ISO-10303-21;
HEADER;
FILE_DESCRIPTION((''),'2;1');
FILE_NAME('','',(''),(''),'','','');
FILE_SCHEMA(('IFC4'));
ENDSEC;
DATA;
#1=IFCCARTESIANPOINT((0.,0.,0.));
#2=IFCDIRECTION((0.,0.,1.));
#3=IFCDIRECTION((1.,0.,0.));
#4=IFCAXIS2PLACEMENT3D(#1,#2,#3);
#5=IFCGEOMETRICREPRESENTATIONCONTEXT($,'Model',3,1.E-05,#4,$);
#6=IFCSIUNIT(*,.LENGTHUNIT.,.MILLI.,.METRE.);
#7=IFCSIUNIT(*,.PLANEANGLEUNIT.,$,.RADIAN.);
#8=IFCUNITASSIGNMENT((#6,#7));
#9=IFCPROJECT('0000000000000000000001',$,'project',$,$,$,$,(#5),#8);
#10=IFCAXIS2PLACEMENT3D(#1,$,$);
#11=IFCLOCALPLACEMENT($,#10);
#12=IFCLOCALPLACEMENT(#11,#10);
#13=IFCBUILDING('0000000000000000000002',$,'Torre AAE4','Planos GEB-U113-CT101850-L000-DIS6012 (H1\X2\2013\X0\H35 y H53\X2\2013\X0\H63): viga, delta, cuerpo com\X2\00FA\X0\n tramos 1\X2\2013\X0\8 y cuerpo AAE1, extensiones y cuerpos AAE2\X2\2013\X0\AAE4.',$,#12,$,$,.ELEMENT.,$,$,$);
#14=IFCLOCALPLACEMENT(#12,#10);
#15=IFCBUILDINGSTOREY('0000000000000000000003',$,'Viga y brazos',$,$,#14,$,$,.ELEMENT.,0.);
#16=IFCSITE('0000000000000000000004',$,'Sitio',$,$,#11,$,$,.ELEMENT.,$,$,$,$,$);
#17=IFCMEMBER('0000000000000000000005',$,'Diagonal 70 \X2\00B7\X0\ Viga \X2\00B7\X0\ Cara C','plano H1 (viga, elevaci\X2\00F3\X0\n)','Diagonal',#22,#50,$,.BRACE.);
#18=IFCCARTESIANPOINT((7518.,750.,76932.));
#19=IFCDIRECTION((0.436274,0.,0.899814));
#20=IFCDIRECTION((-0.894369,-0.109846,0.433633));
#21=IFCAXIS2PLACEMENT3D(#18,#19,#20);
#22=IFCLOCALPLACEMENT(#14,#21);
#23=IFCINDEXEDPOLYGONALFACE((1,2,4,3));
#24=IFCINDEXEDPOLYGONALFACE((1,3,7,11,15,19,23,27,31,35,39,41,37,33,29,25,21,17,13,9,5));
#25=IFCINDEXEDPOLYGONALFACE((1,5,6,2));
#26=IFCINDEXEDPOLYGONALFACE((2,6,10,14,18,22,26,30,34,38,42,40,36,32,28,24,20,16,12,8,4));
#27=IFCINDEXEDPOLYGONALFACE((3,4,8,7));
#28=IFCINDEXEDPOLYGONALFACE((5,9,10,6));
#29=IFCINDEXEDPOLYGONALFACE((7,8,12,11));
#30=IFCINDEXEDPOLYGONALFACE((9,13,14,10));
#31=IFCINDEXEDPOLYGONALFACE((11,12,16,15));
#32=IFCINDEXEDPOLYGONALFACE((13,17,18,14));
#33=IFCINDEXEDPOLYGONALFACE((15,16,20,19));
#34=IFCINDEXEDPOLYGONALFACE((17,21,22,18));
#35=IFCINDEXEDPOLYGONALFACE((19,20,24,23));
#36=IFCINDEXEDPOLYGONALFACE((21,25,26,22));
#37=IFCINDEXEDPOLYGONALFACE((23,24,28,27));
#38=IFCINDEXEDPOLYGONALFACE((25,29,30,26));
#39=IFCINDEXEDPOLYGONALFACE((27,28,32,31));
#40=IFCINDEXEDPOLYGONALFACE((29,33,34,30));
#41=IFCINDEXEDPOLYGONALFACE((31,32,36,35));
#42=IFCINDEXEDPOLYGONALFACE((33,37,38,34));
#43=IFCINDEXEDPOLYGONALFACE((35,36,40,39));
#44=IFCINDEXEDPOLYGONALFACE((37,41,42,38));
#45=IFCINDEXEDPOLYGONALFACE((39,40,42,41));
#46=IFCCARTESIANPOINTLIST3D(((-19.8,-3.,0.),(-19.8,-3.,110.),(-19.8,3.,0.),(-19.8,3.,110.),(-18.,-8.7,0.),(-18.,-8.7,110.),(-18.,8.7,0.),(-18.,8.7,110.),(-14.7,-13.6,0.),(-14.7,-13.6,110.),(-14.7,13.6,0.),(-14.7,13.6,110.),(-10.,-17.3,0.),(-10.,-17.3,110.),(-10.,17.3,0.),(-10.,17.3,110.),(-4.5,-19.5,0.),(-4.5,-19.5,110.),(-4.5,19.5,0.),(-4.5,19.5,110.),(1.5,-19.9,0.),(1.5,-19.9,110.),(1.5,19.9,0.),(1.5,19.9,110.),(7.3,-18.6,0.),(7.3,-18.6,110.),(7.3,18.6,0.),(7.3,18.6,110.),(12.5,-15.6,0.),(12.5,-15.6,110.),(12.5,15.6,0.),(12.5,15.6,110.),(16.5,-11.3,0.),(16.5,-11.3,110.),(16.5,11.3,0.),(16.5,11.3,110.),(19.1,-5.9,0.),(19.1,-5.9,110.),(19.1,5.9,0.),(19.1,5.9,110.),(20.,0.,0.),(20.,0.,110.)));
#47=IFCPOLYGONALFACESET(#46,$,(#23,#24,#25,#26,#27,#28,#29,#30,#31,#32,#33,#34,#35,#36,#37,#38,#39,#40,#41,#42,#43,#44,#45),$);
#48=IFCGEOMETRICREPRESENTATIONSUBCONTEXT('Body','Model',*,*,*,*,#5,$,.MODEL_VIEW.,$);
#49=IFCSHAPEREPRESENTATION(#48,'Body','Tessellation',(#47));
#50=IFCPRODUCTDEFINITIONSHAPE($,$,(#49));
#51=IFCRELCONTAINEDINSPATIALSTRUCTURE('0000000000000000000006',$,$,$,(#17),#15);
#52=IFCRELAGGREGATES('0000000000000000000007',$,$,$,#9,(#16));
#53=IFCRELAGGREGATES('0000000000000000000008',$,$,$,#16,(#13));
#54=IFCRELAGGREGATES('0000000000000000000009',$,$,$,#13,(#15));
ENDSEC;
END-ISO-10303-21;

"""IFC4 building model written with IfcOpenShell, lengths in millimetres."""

from ifc_helpers import new_model, si_unit, frame, origin, origin_with_axes, place, context, subcontext, project, spatial, circle, extrude, element, save


model = new_model("IFC4")

# Units and contexts
model_context = context("Model", 3, precision=1e-05, world=origin_with_axes())
body_context = subcontext(model_context, "Body", "Model", "MODEL_VIEW")
ifc_project = project(units=[si_unit("LENGTHUNIT", "METRE", prefix="MILLI"), si_unit("PLANEANGLEUNIT", "RADIAN")], contexts=[model_context])

# Site, building, storey
site_placement = place(None, origin())
site = spatial("IfcSite", under=ifc_project, at=site_placement, Name="Sitio", CompositionType="ELEMENT")
building_placement = place(site_placement, origin())
building = spatial("IfcBuilding", under=site, at=building_placement, Name="Torre AAE4", Description="Planos GEB-U113-CT101850-L000-DIS6012 (H1–H35 y H53–H63): viga, delta, cuerpo común tramos 1–8 y cuerpo AAE1, extensiones y cuerpos AAE2–AAE4.", CompositionType="ELEMENT")
storey_placement = place(building_placement, origin())
storey = spatial("IfcBuildingStorey", under=building, at=storey_placement, Name="Viga y brazos", CompositionType="ELEMENT", Elevation=0.0)

# Member
for number, where, z_axis, x_axis, name in (
    (1, (7518.0, 750.0, 76932.0), (0.436274, 0.0, 0.899814), (-0.894369, -0.109846, 0.433633), "Diagonal 70 · Viga · Cara C"),
):
    element("IfcMember", number, at=place(storey_placement, frame(where, z_axis=z_axis, x_axis=x_axis)), inside=storey, Name=name, Description="plano H1 (viga, elevación)", ObjectType="Diagonal", PredefinedType="BRACE", context=body_context, shape_type="SweptSolid", body=[
        extrude(circle(Radius=20.0), None, (0.0, 0.0, 1.0), 110.0),
    ])

save(model, "model.ifc")
